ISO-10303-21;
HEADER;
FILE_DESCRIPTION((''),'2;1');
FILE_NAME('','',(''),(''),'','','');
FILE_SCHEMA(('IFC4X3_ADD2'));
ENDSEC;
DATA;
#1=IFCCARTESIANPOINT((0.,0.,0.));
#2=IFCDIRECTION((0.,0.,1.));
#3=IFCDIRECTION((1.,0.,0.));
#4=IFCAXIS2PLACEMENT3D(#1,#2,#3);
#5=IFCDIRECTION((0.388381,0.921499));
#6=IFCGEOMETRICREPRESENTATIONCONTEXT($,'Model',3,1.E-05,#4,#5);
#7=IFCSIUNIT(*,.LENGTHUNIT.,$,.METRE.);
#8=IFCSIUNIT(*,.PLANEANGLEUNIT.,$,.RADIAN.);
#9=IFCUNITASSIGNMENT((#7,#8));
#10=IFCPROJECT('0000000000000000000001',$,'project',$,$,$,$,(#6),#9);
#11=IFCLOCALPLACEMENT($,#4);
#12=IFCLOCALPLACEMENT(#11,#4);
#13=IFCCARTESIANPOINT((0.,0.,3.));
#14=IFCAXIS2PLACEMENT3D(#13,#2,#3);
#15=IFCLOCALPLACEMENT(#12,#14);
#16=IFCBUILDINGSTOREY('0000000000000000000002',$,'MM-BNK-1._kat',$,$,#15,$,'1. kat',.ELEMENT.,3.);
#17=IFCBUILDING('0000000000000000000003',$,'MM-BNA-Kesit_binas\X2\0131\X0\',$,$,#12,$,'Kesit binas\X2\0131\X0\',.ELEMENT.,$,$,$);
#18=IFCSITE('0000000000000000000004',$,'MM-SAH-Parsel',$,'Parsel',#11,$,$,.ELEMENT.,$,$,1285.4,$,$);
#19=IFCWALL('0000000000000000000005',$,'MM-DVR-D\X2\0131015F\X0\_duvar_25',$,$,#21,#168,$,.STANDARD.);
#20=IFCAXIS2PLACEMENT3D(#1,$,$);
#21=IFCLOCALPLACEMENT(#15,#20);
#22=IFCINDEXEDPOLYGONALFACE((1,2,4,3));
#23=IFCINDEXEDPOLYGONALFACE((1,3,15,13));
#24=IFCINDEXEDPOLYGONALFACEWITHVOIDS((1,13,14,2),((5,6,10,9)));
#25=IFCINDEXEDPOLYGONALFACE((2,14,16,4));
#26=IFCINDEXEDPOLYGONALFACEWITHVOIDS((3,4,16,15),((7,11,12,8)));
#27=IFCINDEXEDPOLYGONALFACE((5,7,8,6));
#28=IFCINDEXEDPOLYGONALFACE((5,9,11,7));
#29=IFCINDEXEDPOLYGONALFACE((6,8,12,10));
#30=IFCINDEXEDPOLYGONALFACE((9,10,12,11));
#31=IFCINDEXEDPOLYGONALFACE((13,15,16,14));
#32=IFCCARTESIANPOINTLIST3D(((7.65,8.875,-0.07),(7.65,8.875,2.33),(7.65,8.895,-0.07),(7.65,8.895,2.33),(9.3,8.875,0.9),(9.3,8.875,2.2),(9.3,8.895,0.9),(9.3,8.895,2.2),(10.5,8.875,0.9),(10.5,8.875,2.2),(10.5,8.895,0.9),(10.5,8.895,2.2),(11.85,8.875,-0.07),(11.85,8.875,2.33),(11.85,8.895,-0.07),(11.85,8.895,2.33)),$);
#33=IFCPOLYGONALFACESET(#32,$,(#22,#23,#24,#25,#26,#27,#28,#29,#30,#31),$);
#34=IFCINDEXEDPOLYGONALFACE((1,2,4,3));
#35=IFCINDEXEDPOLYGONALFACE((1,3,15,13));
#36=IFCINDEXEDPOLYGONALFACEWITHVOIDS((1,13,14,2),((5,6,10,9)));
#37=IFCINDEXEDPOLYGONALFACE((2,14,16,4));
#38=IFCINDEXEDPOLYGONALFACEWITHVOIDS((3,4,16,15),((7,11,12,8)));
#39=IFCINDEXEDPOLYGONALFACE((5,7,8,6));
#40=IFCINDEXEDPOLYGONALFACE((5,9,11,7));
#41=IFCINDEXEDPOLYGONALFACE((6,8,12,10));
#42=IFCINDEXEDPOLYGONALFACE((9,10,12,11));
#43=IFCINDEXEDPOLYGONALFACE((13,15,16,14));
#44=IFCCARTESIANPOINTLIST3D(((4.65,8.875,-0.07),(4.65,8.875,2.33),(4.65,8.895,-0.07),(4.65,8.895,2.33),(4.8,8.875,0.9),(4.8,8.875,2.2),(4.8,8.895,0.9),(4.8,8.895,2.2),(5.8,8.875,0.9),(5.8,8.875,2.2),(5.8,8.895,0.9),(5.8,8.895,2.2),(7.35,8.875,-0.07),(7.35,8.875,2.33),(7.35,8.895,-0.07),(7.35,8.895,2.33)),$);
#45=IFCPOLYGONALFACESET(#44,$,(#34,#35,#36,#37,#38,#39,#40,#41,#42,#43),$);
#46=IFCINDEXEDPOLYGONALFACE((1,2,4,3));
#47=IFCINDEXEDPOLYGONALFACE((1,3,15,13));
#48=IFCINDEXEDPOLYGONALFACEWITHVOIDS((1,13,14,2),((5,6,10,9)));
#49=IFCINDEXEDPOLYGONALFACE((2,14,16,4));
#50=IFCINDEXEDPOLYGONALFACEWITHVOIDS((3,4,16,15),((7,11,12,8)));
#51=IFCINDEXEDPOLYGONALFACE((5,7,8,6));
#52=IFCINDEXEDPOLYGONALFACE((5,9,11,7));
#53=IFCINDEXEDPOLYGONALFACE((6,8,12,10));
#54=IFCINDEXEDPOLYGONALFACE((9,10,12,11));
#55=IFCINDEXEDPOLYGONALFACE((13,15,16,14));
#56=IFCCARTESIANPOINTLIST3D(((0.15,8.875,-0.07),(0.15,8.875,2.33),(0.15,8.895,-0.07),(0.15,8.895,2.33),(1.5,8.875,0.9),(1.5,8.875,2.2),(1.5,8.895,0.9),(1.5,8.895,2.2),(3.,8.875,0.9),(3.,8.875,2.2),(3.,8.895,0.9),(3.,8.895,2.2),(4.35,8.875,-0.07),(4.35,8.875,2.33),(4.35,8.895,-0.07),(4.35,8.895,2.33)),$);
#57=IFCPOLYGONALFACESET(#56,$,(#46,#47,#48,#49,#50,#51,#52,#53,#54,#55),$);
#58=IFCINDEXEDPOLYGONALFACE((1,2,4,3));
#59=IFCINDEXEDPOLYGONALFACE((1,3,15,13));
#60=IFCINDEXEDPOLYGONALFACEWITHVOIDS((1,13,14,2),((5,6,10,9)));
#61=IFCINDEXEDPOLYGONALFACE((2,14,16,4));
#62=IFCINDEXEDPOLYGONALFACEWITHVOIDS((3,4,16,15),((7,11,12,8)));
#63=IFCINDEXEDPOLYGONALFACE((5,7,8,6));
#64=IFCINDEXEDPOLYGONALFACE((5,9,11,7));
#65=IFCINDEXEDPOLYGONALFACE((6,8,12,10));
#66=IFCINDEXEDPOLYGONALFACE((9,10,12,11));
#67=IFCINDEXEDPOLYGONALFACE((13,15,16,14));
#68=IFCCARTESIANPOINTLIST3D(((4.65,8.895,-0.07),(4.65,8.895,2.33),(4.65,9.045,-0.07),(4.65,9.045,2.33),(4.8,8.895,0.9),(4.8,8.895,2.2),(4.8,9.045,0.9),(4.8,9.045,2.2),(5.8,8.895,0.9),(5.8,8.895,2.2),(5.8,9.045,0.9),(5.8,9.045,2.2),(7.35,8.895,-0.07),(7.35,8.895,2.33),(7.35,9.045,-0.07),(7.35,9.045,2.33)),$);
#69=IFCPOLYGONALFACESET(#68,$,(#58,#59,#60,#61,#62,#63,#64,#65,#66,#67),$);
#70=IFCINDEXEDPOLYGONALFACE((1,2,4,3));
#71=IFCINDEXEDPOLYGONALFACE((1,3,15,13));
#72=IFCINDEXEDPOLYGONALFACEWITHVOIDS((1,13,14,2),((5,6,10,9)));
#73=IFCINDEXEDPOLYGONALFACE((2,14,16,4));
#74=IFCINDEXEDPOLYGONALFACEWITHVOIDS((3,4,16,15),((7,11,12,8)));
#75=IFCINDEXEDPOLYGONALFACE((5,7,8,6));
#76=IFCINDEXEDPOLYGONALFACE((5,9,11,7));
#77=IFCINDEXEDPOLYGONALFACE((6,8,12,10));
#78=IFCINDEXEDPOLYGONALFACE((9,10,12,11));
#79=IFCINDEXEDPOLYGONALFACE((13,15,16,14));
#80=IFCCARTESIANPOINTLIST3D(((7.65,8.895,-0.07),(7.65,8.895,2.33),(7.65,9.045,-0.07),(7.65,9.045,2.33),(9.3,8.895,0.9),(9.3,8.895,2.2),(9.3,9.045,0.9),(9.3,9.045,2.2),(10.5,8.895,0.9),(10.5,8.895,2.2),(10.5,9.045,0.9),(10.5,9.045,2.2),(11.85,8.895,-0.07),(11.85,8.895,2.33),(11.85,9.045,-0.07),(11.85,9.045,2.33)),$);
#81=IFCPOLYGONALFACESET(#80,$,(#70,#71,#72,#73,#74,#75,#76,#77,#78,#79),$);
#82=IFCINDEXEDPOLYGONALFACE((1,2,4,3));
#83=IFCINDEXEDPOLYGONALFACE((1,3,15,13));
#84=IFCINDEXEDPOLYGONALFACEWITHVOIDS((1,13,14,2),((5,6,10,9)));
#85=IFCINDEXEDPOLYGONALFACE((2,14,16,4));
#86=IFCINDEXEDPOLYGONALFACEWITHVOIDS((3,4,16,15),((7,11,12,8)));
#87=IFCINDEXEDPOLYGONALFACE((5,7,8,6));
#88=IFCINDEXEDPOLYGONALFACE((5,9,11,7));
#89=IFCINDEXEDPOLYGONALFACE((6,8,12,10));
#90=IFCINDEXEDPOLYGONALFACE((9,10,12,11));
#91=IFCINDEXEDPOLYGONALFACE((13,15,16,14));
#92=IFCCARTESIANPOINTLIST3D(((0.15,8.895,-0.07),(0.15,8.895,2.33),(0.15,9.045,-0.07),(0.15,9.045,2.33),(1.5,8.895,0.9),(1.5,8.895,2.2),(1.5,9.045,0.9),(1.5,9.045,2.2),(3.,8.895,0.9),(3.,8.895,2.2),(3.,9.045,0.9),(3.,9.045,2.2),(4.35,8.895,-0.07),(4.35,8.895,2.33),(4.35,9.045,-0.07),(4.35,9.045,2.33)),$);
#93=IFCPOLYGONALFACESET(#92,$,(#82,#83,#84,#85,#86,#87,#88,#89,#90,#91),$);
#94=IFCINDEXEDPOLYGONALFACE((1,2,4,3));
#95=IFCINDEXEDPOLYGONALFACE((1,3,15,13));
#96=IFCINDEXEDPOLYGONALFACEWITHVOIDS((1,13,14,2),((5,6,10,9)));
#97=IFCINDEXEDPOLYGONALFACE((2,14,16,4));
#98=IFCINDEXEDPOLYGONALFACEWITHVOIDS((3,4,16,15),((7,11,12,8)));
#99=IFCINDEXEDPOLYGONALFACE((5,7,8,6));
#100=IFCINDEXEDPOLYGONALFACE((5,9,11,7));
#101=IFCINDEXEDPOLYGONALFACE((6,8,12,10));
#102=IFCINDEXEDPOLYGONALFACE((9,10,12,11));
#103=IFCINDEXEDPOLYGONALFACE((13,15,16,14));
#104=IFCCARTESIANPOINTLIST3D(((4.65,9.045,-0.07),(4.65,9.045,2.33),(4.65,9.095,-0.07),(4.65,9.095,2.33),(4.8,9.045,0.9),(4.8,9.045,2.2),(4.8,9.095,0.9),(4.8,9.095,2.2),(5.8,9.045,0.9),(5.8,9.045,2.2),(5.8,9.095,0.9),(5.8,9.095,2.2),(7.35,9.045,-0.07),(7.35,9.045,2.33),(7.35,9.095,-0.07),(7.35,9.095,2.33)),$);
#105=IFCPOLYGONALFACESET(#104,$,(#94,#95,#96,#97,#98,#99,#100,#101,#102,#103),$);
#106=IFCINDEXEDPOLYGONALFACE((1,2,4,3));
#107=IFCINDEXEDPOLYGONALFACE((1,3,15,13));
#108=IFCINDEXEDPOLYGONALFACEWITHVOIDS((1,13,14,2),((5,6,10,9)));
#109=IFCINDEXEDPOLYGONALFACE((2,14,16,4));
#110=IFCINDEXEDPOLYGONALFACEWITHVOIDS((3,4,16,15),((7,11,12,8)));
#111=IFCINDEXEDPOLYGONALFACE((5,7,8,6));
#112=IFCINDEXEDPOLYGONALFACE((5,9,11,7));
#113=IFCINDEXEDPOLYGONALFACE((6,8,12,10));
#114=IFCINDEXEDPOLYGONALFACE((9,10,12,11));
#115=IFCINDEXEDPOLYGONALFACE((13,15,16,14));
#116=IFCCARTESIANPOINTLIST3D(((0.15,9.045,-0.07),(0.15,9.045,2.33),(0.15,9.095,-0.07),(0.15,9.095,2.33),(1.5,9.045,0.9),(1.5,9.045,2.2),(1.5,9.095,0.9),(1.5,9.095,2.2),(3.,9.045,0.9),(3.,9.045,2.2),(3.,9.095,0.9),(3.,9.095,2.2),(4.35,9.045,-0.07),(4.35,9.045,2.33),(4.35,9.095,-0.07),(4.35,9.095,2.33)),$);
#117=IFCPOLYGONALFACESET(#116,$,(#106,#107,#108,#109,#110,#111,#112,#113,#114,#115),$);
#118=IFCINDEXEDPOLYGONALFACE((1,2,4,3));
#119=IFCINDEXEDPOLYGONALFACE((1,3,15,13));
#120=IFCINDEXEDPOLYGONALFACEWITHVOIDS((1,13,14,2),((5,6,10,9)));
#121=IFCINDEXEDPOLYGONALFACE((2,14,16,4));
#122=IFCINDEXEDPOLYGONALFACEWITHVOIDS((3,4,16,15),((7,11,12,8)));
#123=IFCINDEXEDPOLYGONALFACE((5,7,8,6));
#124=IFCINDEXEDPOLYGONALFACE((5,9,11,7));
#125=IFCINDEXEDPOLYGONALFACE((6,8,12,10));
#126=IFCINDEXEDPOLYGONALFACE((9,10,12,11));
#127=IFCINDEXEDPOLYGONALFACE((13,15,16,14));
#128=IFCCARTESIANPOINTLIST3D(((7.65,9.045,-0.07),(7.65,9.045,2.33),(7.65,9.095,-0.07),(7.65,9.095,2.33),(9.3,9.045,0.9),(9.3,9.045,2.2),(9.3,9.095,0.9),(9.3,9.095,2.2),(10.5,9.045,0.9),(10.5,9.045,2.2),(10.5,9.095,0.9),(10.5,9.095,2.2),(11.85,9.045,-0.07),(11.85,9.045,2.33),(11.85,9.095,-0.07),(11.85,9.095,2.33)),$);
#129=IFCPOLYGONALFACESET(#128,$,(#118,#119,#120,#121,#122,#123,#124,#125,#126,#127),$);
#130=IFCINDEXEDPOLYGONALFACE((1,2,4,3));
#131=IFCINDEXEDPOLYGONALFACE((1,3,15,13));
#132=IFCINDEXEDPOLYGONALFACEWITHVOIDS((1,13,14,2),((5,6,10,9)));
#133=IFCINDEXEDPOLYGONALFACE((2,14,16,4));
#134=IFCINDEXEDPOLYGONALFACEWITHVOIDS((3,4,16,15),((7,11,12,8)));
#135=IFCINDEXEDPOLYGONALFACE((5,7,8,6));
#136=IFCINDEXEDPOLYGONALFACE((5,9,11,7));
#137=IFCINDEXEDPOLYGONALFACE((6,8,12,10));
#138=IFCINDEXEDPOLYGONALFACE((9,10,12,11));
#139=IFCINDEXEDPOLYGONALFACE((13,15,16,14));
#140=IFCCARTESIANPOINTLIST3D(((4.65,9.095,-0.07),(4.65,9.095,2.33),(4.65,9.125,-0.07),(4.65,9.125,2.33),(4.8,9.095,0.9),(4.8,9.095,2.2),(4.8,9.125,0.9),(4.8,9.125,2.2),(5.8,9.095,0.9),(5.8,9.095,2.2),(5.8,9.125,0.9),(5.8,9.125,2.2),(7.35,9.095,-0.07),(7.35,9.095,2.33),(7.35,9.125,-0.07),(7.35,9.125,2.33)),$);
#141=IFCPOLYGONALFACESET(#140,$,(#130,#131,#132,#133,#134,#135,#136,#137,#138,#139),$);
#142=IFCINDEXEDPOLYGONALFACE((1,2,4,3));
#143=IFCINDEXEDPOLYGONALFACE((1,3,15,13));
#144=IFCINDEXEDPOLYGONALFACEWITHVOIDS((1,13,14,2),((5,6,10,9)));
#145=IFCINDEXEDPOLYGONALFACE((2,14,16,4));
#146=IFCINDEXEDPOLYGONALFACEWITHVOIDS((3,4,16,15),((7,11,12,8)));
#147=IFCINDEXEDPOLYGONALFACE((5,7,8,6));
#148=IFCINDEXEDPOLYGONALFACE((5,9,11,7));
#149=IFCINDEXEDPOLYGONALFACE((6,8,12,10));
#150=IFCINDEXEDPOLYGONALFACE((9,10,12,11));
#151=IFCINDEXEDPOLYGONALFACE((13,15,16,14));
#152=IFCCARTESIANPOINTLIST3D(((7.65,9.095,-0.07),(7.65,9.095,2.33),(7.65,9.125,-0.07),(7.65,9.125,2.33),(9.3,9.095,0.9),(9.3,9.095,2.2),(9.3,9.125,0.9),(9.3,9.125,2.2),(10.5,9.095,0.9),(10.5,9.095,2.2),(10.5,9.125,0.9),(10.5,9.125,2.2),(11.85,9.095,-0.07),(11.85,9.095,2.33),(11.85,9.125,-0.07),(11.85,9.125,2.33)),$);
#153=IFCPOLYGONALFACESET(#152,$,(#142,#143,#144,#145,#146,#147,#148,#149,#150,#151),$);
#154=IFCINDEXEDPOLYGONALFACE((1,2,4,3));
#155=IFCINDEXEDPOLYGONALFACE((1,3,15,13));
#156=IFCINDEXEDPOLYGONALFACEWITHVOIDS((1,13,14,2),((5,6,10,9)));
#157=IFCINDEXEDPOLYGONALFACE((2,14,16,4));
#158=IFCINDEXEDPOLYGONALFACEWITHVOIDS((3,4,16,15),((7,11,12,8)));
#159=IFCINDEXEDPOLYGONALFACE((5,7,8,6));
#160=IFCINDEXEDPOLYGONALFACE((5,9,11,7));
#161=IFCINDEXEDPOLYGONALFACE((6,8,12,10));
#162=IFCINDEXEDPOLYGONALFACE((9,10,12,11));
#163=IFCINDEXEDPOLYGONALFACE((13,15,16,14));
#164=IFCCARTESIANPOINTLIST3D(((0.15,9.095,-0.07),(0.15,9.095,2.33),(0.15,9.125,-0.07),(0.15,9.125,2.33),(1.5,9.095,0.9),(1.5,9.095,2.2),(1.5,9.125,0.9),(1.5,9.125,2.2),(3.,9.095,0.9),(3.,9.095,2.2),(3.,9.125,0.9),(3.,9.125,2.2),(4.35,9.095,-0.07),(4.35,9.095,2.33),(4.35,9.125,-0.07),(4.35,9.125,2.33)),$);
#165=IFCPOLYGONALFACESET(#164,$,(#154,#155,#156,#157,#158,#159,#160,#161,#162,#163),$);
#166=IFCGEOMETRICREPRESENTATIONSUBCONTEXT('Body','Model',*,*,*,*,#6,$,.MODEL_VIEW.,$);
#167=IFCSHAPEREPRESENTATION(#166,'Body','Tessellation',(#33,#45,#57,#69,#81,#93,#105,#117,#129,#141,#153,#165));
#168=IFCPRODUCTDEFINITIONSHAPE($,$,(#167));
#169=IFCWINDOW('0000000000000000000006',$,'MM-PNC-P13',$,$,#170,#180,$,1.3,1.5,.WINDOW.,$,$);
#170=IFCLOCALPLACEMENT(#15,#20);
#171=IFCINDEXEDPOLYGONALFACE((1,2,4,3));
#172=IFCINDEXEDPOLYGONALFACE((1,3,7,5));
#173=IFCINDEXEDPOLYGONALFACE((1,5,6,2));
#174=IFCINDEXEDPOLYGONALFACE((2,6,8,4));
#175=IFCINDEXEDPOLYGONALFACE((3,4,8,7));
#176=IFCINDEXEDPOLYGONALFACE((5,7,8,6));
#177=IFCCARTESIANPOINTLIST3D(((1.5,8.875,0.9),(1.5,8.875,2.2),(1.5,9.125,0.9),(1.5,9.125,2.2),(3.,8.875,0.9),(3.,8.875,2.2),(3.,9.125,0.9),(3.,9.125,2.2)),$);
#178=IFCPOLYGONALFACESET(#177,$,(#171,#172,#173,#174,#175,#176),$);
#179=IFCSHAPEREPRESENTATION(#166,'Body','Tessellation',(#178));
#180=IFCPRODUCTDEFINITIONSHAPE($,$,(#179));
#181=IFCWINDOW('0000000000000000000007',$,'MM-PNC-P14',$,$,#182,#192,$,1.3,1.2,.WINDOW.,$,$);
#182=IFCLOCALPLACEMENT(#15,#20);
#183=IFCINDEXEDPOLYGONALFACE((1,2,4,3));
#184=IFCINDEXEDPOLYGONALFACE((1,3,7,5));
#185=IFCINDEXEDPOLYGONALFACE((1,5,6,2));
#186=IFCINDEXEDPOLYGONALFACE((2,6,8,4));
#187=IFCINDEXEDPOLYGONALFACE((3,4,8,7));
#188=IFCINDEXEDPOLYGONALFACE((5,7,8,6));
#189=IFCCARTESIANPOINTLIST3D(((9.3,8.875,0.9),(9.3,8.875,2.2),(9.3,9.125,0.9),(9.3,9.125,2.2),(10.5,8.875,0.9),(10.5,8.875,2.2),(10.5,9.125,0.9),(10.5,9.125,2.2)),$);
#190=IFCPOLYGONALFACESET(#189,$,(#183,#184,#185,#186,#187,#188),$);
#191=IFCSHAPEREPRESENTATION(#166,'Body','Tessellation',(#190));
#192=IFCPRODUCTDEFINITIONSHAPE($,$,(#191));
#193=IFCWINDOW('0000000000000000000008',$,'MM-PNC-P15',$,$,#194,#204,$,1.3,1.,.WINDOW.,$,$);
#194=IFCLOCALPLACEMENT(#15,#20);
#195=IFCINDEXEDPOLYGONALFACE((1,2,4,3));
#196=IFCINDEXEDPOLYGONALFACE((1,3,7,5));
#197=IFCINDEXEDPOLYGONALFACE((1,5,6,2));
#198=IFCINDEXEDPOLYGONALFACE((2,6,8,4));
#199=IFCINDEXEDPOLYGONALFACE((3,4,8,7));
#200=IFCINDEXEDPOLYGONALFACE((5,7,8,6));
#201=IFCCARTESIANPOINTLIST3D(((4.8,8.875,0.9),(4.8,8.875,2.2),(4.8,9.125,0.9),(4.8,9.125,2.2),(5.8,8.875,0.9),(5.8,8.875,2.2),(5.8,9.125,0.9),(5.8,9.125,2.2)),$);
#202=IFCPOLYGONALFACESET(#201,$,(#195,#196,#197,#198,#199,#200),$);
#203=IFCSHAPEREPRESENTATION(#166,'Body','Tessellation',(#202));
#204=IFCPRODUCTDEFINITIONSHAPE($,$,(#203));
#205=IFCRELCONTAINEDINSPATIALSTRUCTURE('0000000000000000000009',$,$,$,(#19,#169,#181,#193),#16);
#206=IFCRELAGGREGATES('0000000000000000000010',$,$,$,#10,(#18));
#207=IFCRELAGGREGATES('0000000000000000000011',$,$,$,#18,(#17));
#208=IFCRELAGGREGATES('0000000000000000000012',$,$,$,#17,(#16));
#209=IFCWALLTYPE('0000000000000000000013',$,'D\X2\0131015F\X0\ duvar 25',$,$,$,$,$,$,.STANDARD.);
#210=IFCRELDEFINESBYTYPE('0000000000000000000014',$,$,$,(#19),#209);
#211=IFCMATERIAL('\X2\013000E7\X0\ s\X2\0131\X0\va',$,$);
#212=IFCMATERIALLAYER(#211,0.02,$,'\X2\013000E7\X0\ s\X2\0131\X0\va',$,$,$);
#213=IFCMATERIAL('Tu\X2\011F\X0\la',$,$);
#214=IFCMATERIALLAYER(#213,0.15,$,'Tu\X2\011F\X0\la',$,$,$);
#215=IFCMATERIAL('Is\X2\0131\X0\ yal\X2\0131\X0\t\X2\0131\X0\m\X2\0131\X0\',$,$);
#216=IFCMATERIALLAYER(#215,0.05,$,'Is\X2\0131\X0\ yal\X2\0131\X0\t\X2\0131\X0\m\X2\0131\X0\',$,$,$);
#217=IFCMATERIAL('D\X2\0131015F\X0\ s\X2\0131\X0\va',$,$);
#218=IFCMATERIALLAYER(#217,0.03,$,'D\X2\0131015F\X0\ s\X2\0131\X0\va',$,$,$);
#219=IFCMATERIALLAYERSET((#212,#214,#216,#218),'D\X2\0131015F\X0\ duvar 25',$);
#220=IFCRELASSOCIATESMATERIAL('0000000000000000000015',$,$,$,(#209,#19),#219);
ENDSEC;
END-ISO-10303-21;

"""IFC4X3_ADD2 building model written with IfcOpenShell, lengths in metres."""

from ifc_helpers import new_model, si_unit, direction, frame, origin_with_axes, place, context, subcontext, project, spatial, polyline, outline, extrude, material, layer, layer_set, type_object, element, fill, save


model = new_model("IFC4X3_ADD2")

# Units and contexts
model_context = context("Model", 3, precision=1e-05, world=origin_with_axes(), true_north=direction((0.388381, 0.921499)))
body_context = subcontext(model_context, "Body", "Model", "MODEL_VIEW")
ifc_project = project(units=[si_unit("LENGTHUNIT", "METRE"), si_unit("PLANEANGLEUNIT", "RADIAN")], contexts=[model_context])

# Site, building, storey
site_placement = place(None, origin_with_axes())
site = spatial("IfcSite", under=ifc_project, at=site_placement, Name="MM-SAH-Parsel", ObjectType="Parsel", CompositionType="ELEMENT", RefElevation=1285.4)
building_placement = place(site_placement, origin_with_axes())
building = spatial("IfcBuilding", under=site, at=building_placement, Name="MM-BNA-Kesit_binası", LongName="Kesit binası", CompositionType="ELEMENT")
storey_placement = place(building_placement, frame((0.0, 0.0, 3.0), z_axis=(0.0, 0.0, 1.0), x_axis=(1.0, 0.0, 0.0)))
storey = spatial("IfcBuildingStorey", under=building, at=storey_placement, Name="MM-BNK-1._kat", LongName="1. kat", CompositionType="ELEMENT", Elevation=3.0)

# Shared definitions
ifc_material_1 = material(Name="İç sıva")
ifc_layer_1 = layer(ifc_material_1, 0.02, Name="İç sıva")
ifc_material_2 = material(Name="Tuğla")
ifc_layer_2 = layer(ifc_material_2, 0.15, Name="Tuğla")
ifc_material_3 = material(Name="Isı yalıtımı")
ifc_layer_3 = layer(ifc_material_3, 0.05, Name="Isı yalıtımı")
ifc_material_4 = material(Name="Dış sıva")
ifc_layer_4 = layer(ifc_material_4, 0.03, Name="Dış sıva")
ifc_layer_set_1 = layer_set([ifc_layer_1, ifc_layer_2, ifc_layer_3, ifc_layer_4], Name="Dış duvar 25")
wall_type_1 = type_object("IfcWallType", Name="Dış duvar 25", PredefinedType="STANDARD", material=ifc_layer_set_1)

# Wall, openings, windows
wall_1_placement = place(storey_placement, origin_with_axes())
wall_1 = element("IfcWall", 1, at=wall_1_placement, inside=storey, type_object=wall_type_1, material=ifc_layer_set_1, Name="MM-DVR-Dış_duvar_25", PredefinedType="STANDARD", context=body_context, shape_type="SweptSolid", body=[
    extrude(outline(polyline([(11.85, 8.895), (7.65, 8.895), (7.65, 8.875), (11.85, 8.875), (11.85, 8.895)])), frame((0.0, 0.0, -0.07)), (0.0, 0.0, 1.0), 2.4),
    extrude(outline(polyline([(7.35, 8.895), (4.65, 8.895), (4.65, 8.875), (7.35, 8.875), (7.35, 8.895)])), frame((0.0, 0.0, -0.07)), (0.0, 0.0, 1.0), 2.4),
    extrude(outline(polyline([(4.35, 8.895), (0.15, 8.895), (0.15, 8.875), (4.35, 8.875), (4.35, 8.895)])), frame((0.0, 0.0, -0.07)), (0.0, 0.0, 1.0), 2.4),
    extrude(outline(polyline([(7.35, 9.045), (4.65, 9.045), (4.65, 8.895), (7.35, 8.895), (7.35, 9.045)])), frame((0.0, 0.0, -0.07)), (0.0, 0.0, 1.0), 2.4),
    extrude(outline(polyline([(11.85, 9.045), (7.65, 9.045), (7.65, 8.895), (11.85, 8.895), (11.85, 9.045)])), frame((0.0, 0.0, -0.07)), (0.0, 0.0, 1.0), 2.4),
    extrude(outline(polyline([(4.35, 9.045), (0.15, 9.045), (0.15, 8.895), (4.35, 8.895), (4.35, 9.045)])), frame((0.0, 0.0, -0.07)), (0.0, 0.0, 1.0), 2.4),
    extrude(outline(polyline([(7.35, 9.095), (4.65, 9.095), (4.65, 9.045), (7.35, 9.045), (7.35, 9.095)])), frame((0.0, 0.0, -0.07)), (0.0, 0.0, 1.0), 2.4),
    extrude(outline(polyline([(4.35, 9.095), (0.15, 9.095), (0.15, 9.045), (4.35, 9.045), (4.35, 9.095)])), frame((0.0, 0.0, -0.07)), (0.0, 0.0, 1.0), 2.4),
    extrude(outline(polyline([(11.85, 9.095), (7.65, 9.095), (7.65, 9.045), (11.85, 9.045), (11.85, 9.095)])), frame((0.0, 0.0, -0.07)), (0.0, 0.0, 1.0), 2.4),
    extrude(outline(polyline([(7.35, 9.125), (4.65, 9.125), (4.65, 9.095), (7.35, 9.095), (7.35, 9.125)])), frame((0.0, 0.0, -0.07)), (0.0, 0.0, 1.0), 2.4),
    extrude(outline(polyline([(11.85, 9.125), (7.65, 9.125), (7.65, 9.095), (11.85, 9.095), (11.85, 9.125)])), frame((0.0, 0.0, -0.07)), (0.0, 0.0, 1.0), 2.4),
    extrude(outline(polyline([(4.35, 9.125), (0.15, 9.125), (0.15, 9.095), (4.35, 9.095), (4.35, 9.125)])), frame((0.0, 0.0, -0.07)), (0.0, 0.0, 1.0), 2.4),
])
opening_1_placement = place(storey_placement, origin_with_axes())
opening_1 = element("IfcOpeningElement", 2, at=opening_1_placement, cuts=wall_1, PredefinedType="OPENING", context=body_context, shape_type="SweptSolid", body=[
    extrude(outline(polyline([(3.0, 8.875), (1.5, 8.875), (1.5, 9.125), (3.0, 9.125), (3.0, 8.875)])), frame((0.0, 0.0, 0.9)), (0.0, 0.0, 1.0), 1.3),
])
opening_2_placement = place(storey_placement, origin_with_axes())
opening_2 = element("IfcOpeningElement", 3, at=opening_2_placement, cuts=wall_1, PredefinedType="OPENING", context=body_context, shape_type="SweptSolid", body=[
    extrude(outline(polyline([(10.5, 8.875), (9.3, 8.875), (9.3, 9.125), (10.5, 9.125), (10.5, 8.875)])), frame((0.0, 0.0, 0.9)), (0.0, 0.0, 1.0), 1.3),
])
opening_3_placement = place(storey_placement, origin_with_axes())
opening_3 = element("IfcOpeningElement", 4, at=opening_3_placement, cuts=wall_1, PredefinedType="OPENING", context=body_context, shape_type="SweptSolid", body=[
    extrude(outline(polyline([(5.8, 8.875), (4.8, 8.875), (4.8, 9.125), (5.8, 9.125), (5.8, 8.875)])), frame((0.0, 0.0, 0.9)), (0.0, 0.0, 1.0), 1.3),
])
window_1_placement = place(storey_placement, origin_with_axes())
window_1 = element("IfcWindow", 5, at=window_1_placement, inside=storey, Name="MM-PNC-P13", OverallHeight=1.3, OverallWidth=1.5, PredefinedType="WINDOW", context=body_context, shape_type="SweptSolid", body=[
    extrude(outline(polyline([(3.0, 8.875), (1.5, 8.875), (1.5, 9.125), (3.0, 9.125), (3.0, 8.875)])), frame((0.0, 0.0, 0.9)), (0.0, 0.0, 1.0), 1.3),
])
fill(opening_1, window_1)
window_2_placement = place(storey_placement, origin_with_axes())
window_2 = element("IfcWindow", 6, at=window_2_placement, inside=storey, Name="MM-PNC-P14", OverallHeight=1.3, OverallWidth=1.2, PredefinedType="WINDOW", context=body_context, shape_type="SweptSolid", body=[
    extrude(outline(polyline([(10.5, 8.875), (9.3, 8.875), (9.3, 9.125), (10.5, 9.125), (10.5, 8.875)])), frame((0.0, 0.0, 0.9)), (0.0, 0.0, 1.0), 1.3),
])
fill(opening_2, window_2)
window_3_placement = place(storey_placement, origin_with_axes())
window_3 = element("IfcWindow", 7, at=window_3_placement, inside=storey, Name="MM-PNC-P15", OverallHeight=1.3, OverallWidth=1.0, PredefinedType="WINDOW", context=body_context, shape_type="SweptSolid", body=[
    extrude(outline(polyline([(5.8, 8.875), (4.8, 8.875), (4.8, 9.125), (5.8, 9.125), (5.8, 8.875)])), frame((0.0, 0.0, 0.9)), (0.0, 0.0, 1.0), 1.3),
])
fill(opening_3, window_3)

save(model, "model.ifc")
